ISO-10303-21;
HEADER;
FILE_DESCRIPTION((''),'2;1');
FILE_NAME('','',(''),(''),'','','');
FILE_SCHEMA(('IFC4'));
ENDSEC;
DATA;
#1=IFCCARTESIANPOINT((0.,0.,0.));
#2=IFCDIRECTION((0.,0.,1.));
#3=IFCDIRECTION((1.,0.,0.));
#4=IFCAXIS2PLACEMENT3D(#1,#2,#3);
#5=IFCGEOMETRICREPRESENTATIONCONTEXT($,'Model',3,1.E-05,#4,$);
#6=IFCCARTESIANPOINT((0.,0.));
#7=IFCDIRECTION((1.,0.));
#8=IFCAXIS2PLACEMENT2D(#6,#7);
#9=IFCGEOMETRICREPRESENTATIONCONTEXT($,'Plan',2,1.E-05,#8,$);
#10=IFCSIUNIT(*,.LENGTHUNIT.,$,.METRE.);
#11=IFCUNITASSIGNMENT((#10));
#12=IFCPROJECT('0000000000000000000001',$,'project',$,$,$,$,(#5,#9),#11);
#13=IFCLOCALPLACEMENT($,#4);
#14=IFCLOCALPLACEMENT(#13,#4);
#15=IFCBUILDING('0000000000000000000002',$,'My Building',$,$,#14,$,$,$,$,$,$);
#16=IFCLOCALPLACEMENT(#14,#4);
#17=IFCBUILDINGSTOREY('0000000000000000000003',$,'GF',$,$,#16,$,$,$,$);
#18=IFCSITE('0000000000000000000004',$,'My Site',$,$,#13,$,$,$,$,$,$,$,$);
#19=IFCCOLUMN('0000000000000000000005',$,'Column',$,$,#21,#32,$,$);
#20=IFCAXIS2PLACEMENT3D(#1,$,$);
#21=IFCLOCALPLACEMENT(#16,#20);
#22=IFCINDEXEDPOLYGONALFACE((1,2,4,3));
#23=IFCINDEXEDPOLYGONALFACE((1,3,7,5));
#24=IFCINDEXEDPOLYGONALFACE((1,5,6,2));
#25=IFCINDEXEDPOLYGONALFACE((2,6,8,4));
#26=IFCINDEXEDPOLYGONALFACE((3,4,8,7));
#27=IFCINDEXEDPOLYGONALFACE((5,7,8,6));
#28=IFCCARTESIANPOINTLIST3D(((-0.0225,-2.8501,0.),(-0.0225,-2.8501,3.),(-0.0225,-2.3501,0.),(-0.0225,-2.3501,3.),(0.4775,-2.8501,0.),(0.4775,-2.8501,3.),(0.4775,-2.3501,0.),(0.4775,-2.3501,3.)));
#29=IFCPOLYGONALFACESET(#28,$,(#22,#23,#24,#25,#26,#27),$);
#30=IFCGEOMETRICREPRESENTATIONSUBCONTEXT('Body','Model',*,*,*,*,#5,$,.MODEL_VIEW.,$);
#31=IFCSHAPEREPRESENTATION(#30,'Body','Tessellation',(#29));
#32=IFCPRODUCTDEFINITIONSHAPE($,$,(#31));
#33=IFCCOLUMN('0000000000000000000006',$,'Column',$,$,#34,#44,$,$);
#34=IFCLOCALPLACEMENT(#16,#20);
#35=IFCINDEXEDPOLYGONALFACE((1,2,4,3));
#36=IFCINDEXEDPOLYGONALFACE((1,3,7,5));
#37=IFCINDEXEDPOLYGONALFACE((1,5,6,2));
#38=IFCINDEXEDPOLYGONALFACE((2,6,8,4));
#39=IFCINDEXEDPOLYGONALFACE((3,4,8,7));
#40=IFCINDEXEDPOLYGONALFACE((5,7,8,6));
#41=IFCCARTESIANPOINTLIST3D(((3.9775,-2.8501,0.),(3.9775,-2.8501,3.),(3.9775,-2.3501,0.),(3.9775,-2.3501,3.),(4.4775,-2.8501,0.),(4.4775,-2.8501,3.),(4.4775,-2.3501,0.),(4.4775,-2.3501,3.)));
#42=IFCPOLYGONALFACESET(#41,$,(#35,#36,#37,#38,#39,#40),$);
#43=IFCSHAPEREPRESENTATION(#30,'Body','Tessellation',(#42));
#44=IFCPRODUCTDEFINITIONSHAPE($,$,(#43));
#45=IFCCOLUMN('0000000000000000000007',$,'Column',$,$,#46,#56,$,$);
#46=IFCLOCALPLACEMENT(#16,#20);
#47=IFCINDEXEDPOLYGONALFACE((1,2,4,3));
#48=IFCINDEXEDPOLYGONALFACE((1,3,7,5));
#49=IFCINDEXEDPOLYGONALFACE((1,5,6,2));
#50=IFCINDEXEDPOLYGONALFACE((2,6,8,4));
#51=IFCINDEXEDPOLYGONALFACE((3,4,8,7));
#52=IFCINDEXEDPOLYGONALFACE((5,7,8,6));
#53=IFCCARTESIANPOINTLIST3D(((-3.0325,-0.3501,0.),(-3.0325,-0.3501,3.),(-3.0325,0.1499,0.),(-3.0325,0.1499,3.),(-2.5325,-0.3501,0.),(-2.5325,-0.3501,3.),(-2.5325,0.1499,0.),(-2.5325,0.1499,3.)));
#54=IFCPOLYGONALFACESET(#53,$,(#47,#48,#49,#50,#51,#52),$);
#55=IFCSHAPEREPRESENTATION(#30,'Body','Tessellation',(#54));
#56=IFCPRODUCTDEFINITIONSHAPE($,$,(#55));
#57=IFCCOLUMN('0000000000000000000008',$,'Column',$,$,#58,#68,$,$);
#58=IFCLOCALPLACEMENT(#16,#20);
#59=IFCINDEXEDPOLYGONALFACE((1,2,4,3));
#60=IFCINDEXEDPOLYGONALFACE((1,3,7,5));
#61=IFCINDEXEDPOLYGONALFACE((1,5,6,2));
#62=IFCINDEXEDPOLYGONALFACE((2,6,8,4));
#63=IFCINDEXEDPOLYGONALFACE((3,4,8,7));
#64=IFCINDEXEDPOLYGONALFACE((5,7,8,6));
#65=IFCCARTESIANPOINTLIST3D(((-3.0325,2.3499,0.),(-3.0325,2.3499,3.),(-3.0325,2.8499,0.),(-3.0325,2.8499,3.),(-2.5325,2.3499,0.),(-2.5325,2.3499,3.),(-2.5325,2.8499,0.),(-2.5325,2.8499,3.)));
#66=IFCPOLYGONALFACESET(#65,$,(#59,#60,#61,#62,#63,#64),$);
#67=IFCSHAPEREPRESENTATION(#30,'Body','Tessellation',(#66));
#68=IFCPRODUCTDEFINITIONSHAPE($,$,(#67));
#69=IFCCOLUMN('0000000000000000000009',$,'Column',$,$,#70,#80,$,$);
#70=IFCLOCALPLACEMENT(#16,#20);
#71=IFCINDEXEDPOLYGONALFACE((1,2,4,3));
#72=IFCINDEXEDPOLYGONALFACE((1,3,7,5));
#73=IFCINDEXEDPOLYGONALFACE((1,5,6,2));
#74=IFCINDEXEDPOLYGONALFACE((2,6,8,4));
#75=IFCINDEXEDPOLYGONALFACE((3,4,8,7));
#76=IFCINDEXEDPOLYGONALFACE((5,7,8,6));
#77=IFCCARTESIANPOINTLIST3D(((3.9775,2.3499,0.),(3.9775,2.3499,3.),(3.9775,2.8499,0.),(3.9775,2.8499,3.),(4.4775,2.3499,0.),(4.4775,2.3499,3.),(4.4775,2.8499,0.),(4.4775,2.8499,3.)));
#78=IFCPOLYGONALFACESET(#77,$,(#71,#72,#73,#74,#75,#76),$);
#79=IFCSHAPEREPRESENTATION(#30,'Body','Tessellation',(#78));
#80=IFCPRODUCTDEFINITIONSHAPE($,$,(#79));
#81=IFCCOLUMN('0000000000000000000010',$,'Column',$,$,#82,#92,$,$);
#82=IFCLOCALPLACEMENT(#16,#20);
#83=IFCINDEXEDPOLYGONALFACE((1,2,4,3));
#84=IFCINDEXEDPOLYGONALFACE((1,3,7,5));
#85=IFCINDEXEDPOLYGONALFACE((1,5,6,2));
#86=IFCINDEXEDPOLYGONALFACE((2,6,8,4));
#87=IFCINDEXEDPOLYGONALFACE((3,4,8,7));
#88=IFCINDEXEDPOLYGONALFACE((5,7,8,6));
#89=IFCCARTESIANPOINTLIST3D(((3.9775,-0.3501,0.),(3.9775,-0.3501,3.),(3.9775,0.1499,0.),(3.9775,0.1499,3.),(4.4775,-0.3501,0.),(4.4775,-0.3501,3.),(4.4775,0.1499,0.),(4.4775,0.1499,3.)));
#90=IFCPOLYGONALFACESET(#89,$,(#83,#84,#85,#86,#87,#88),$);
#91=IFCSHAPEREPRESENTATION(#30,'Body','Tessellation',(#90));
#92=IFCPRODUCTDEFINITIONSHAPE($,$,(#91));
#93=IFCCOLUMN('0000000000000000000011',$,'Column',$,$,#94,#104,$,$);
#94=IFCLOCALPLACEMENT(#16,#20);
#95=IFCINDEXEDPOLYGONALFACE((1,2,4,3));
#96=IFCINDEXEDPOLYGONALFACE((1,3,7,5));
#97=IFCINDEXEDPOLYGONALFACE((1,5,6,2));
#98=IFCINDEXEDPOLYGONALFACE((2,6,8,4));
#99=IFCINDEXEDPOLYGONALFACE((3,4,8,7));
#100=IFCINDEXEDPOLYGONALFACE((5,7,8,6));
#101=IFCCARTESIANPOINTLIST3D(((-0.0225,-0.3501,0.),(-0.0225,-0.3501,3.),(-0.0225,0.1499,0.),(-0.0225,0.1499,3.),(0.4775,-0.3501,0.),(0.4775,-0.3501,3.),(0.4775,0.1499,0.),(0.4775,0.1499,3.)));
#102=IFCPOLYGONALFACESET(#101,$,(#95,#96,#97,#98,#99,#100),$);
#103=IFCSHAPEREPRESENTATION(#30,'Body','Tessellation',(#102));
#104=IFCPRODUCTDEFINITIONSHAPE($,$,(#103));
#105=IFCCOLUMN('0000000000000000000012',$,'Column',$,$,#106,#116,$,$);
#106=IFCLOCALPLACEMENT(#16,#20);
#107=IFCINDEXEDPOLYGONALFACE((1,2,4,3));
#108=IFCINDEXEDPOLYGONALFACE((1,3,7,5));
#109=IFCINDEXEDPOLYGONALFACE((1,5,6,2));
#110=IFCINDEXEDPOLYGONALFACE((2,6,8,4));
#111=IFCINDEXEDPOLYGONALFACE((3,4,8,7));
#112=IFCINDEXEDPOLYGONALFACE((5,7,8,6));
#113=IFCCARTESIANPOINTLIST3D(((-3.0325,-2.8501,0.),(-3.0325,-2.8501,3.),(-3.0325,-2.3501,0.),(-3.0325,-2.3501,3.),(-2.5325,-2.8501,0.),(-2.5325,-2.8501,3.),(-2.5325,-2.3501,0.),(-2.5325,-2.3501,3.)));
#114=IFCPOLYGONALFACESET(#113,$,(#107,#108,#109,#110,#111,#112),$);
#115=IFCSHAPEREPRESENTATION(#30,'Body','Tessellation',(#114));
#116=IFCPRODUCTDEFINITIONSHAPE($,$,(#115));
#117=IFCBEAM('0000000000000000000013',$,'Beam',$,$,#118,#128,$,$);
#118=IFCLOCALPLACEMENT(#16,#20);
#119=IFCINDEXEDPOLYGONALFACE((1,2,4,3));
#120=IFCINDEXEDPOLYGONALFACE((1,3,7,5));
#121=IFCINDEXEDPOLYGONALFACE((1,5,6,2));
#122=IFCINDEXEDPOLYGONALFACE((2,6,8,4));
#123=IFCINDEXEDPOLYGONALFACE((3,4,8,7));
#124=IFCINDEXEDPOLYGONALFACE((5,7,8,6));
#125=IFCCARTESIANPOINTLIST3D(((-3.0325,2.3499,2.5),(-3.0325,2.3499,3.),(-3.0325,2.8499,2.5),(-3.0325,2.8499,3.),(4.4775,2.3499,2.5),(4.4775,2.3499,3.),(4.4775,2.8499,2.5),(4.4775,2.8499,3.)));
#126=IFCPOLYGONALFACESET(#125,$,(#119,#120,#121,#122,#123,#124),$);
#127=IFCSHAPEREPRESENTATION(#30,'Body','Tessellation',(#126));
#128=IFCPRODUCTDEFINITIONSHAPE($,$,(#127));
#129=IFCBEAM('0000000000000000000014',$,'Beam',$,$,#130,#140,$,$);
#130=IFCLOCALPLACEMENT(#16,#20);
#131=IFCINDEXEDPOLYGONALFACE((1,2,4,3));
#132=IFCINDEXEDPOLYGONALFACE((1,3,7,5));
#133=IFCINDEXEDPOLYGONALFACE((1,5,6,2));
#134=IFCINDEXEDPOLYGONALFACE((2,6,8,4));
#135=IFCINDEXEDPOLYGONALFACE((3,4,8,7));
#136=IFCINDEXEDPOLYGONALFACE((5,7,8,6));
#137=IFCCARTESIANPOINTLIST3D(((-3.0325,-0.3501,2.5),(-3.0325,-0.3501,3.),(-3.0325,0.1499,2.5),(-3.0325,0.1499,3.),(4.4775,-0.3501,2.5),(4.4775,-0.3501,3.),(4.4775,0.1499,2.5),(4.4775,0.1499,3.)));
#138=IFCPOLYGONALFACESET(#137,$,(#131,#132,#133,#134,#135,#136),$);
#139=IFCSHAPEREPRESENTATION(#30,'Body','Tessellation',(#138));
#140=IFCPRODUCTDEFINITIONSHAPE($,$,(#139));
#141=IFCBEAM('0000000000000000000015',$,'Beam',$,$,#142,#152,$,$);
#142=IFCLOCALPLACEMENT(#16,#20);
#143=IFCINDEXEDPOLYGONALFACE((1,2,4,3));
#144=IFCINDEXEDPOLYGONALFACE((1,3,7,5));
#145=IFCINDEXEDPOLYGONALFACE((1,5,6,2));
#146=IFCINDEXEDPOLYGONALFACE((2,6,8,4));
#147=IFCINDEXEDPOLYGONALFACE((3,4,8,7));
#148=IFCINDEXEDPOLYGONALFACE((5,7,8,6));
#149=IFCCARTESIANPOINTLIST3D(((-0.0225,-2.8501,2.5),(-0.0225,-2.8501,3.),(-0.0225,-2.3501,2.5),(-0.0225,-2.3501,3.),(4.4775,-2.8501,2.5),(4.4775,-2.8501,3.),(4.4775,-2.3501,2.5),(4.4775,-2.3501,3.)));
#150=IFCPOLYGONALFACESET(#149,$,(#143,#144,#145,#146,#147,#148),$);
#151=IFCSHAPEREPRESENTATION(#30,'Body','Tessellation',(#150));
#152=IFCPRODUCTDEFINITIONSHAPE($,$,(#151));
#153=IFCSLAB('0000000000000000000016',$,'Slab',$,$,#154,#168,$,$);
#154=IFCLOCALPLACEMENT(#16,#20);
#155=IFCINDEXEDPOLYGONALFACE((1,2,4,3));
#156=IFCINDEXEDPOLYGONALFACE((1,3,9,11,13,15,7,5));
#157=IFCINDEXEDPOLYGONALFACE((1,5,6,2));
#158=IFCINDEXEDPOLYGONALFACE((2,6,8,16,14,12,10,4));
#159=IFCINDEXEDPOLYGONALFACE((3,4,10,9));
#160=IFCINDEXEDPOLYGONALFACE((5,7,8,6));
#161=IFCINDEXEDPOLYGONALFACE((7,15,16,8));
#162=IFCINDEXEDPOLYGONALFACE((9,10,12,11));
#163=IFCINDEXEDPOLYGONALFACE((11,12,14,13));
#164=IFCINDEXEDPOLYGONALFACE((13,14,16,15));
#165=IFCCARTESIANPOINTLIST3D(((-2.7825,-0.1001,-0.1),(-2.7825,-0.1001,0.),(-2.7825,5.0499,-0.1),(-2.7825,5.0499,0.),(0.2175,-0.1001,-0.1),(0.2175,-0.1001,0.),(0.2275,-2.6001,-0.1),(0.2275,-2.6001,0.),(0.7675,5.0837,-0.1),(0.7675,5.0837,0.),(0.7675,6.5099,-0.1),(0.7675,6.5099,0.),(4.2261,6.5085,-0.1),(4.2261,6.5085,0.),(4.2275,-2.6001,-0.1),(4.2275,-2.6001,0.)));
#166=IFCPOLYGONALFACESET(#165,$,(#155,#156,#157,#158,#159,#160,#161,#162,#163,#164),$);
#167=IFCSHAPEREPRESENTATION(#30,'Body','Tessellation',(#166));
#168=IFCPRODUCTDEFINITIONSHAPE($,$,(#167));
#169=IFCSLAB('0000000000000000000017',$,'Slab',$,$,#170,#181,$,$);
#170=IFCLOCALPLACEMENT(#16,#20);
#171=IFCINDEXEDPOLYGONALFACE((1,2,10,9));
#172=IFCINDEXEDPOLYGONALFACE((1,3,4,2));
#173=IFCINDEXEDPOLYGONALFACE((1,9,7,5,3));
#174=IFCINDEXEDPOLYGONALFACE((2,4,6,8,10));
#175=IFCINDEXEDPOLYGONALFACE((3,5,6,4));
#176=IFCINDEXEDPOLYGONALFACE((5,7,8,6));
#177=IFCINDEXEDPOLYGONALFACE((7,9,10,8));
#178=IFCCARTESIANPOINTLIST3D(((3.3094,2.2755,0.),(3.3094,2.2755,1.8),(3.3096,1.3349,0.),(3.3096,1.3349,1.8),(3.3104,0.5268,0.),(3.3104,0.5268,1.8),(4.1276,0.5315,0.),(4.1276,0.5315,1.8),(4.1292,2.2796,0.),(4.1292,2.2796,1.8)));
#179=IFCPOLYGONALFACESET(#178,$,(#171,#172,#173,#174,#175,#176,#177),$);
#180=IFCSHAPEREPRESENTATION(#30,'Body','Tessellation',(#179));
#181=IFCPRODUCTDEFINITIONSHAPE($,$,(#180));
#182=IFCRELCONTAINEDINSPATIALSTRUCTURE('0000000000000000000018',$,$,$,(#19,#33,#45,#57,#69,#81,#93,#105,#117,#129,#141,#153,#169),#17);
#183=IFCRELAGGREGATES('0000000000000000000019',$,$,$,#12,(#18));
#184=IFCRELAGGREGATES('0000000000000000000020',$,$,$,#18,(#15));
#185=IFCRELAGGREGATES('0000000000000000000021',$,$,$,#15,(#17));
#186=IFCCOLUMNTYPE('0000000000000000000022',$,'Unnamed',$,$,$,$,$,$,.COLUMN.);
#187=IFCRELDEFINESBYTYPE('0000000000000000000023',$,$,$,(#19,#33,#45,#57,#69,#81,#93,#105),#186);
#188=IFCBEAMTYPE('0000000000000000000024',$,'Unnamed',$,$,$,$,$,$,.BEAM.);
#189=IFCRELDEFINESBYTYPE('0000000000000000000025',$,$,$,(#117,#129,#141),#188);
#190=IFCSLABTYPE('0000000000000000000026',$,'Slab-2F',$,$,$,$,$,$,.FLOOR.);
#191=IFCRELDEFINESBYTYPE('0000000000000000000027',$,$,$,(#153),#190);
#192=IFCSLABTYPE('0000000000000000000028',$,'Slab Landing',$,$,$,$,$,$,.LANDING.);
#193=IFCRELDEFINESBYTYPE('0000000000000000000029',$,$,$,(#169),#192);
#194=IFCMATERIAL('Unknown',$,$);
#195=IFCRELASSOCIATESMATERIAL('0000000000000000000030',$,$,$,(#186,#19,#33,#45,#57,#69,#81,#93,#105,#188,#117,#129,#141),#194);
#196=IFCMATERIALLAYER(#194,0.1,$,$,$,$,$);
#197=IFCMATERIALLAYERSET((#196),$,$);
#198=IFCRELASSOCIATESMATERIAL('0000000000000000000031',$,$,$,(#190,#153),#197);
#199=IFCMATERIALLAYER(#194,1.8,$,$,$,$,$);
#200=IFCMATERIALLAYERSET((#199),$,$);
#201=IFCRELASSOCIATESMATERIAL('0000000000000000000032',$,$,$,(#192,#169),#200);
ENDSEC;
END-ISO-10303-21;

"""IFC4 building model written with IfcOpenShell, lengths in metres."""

from ifc_helpers import new_model, si_unit, frame, origin_with_axes, origin_2d_with_axis, place, context, subcontext, project, spatial, indexed_curve, rectangle, outline, extrude, material, layer, layer_set, layer_usage, material_profile, profile_set, profile_usage, type_object, element, save


model = new_model("IFC4")

# Units and contexts
model_context = context("Model", 3, precision=1e-05, world=origin_with_axes())
plan_context = context("Plan", 2, precision=1e-05, world=origin_2d_with_axis())
body_context_1 = subcontext(model_context, "Body", "Model", "MODEL_VIEW")
ifc_project = project(units=[si_unit("LENGTHUNIT", "METRE")], contexts=[model_context, plan_context])

# Site, building, storey
site_placement = place(None, origin_with_axes())
site = spatial("IfcSite", under=ifc_project, at=site_placement, Name="My Site")
building_placement = place(site_placement, origin_with_axes())
building = spatial("IfcBuilding", under=site, at=building_placement, Name="My Building")
storey_placement = place(building_placement, origin_with_axes())
storey = spatial("IfcBuildingStorey", under=building, at=storey_placement, Name="GF")

# Columns
ifc_material = material(Name="Unknown")
ifc_material_profile_1 = material_profile(ifc_material, rectangle(XDim=0.5, YDim=0.5))
ifc_profile_set_1 = profile_set([ifc_material_profile_1])
ifc_profile_usage_1 = profile_usage(ifc_profile_set_1, cardinal=5)
column_type = type_object("IfcColumnType", Name="Unnamed", PredefinedType="COLUMN", material=ifc_profile_set_1)
column_1_placement = place(storey_placement, frame((0.2275, -2.6001, 0.0), z_axis=(0.0, 0.0, 1.0), x_axis=(1.0, 0.0, 0.0)))
element("IfcColumn", 1, at=column_1_placement, inside=storey, type_object=column_type, material=ifc_profile_usage_1, Name="Column", context=body_context_1, shape_type="SweptSolid", body=[
    extrude(rectangle(XDim=0.5, YDim=0.5), origin_with_axes(), (0.0, 0.0, 1.0), 3.0),
])
ifc_profile_usage_2 = profile_usage(ifc_profile_set_1, cardinal=5)
column_2_placement = place(storey_placement, frame((4.2275, -2.6001, 0.0), z_axis=(0.0, 0.0, 1.0), x_axis=(1.0, 0.0, 0.0)))
element("IfcColumn", 2, at=column_2_placement, inside=storey, type_object=column_type, material=ifc_profile_usage_2, Name="Column", context=body_context_1, shape_type="SweptSolid", body=[
    extrude(rectangle(XDim=0.5, YDim=0.5), origin_with_axes(), (0.0, 0.0, 1.0), 3.0),
])
ifc_profile_usage_3 = profile_usage(ifc_profile_set_1, cardinal=5)
column_3_placement = place(storey_placement, frame((-2.7825, -0.1001, 0.0), z_axis=(0.0, 0.0, 1.0), x_axis=(1.0, 0.0, 0.0)))
element("IfcColumn", 3, at=column_3_placement, inside=storey, type_object=column_type, material=ifc_profile_usage_3, Name="Column", context=body_context_1, shape_type="SweptSolid", body=[
    extrude(rectangle(XDim=0.5, YDim=0.5), origin_with_axes(), (0.0, 0.0, 1.0), 3.0),
])
ifc_profile_usage_4 = profile_usage(ifc_profile_set_1, cardinal=5)
column_4_placement = place(storey_placement, frame((-2.7825, 2.5999, 0.0), z_axis=(0.0, 0.0, 1.0), x_axis=(1.0, 0.0, 0.0)))
element("IfcColumn", 4, at=column_4_placement, inside=storey, type_object=column_type, material=ifc_profile_usage_4, Name="Column", context=body_context_1, shape_type="SweptSolid", body=[
    extrude(rectangle(XDim=0.5, YDim=0.5), origin_with_axes(), (0.0, 0.0, 1.0), 3.0),
])
ifc_profile_usage_5 = profile_usage(ifc_profile_set_1, cardinal=5)
column_5_placement = place(storey_placement, frame((4.2275, 2.5999, 0.0), z_axis=(0.0, 0.0, 1.0), x_axis=(1.0, 0.0, 0.0)))
element("IfcColumn", 5, at=column_5_placement, inside=storey, type_object=column_type, material=ifc_profile_usage_5, Name="Column", context=body_context_1, shape_type="SweptSolid", body=[
    extrude(rectangle(XDim=0.5, YDim=0.5), origin_with_axes(), (0.0, 0.0, 1.0), 3.0),
])
ifc_profile_usage_6 = profile_usage(ifc_profile_set_1, cardinal=5)
column_6_placement = place(storey_placement, frame((4.2275, -0.1001, 0.0), z_axis=(0.0, 0.0, 1.0), x_axis=(1.0, 0.0, 0.0)))
element("IfcColumn", 6, at=column_6_placement, inside=storey, type_object=column_type, material=ifc_profile_usage_6, Name="Column", context=body_context_1, shape_type="SweptSolid", body=[
    extrude(rectangle(XDim=0.5, YDim=0.5), origin_with_axes(), (0.0, 0.0, 1.0), 3.0),
])
ifc_profile_usage_7 = profile_usage(ifc_profile_set_1, cardinal=5)
column_7_placement = place(storey_placement, frame((0.2275, -0.1001, 0.0), z_axis=(0.0, 0.0, 1.0), x_axis=(1.0, 0.0, 0.0)))
element("IfcColumn", 7, at=column_7_placement, inside=storey, type_object=column_type, material=ifc_profile_usage_7, Name="Column", context=body_context_1, shape_type="SweptSolid", body=[
    extrude(rectangle(XDim=0.5, YDim=0.5), origin_with_axes(), (0.0, 0.0, 1.0), 3.0),
])
ifc_profile_usage_8 = profile_usage(ifc_profile_set_1, cardinal=5)
column_8_placement = place(storey_placement, frame((-2.7825, -2.6001, 0.0), z_axis=(0.0, 0.0, 1.0), x_axis=(1.0, 0.0, 0.0)))
element("IfcColumn", 8, at=column_8_placement, inside=storey, type_object=column_type, material=ifc_profile_usage_8, Name="Column", context=body_context_1, shape_type="SweptSolid", body=[
    extrude(rectangle(XDim=0.5, YDim=0.5), origin_with_axes(), (0.0, 0.0, 1.0), 3.0),
])

# Beams
ifc_material_profile_2 = material_profile(ifc_material, rectangle(XDim=0.5, YDim=0.5))
ifc_profile_set_2 = profile_set([ifc_material_profile_2])
ifc_profile_usage_9 = profile_usage(ifc_profile_set_2, cardinal=7)
beam_type = type_object("IfcBeamType", Name="Unnamed", PredefinedType="BEAM", material=ifc_profile_set_2)
beam_1_placement = place(storey_placement, frame((4.4775, 2.3499, 3.0), z_axis=(-1.0, 0.0, 0.0), x_axis=(0.0, -1.0, 0.0)))
element("IfcBeam", 9, at=beam_1_placement, inside=storey, type_object=beam_type, material=ifc_profile_usage_9, Name="Beam", context=body_context_1, shape_type="SweptSolid", body=[
    extrude(rectangle(XDim=0.5, YDim=0.5), frame((-0.25, -0.25, 0.0), z_axis=(0.0, 0.0, 1.0), x_axis=(1.0, 0.0, 0.0)), (0.0, 0.0, 1.0), 7.51),
])
ifc_profile_usage_10 = profile_usage(ifc_profile_set_2, cardinal=7)
beam_2_placement = place(storey_placement, frame((-3.0325, 0.1499, 3.0), z_axis=(1.0, 0.0, 0.0), x_axis=(0.0, 1.0, 0.0)))
element("IfcBeam", 10, at=beam_2_placement, inside=storey, type_object=beam_type, material=ifc_profile_usage_10, Name="Beam", context=body_context_1, shape_type="SweptSolid", body=[
    extrude(rectangle(XDim=0.5, YDim=0.5), frame((-0.25, -0.25, 0.0), z_axis=(0.0, 0.0, 1.0), x_axis=(1.0, 0.0, 0.0)), (0.0, 0.0, 1.0), 7.51),
])
ifc_profile_usage_11 = profile_usage(ifc_profile_set_2, cardinal=7)
beam_3_placement = place(storey_placement, frame((4.4775, -2.8501, 3.0), z_axis=(-1.0, -0.000001, 0.000001), x_axis=(0.000001, -1.0, 0.000001)))
element("IfcBeam", 11, at=beam_3_placement, inside=storey, type_object=beam_type, material=ifc_profile_usage_11, Name="Beam", context=body_context_1, shape_type="SweptSolid", body=[
    extrude(rectangle(XDim=0.5, YDim=0.5), frame((-0.25, -0.25, 0.0), z_axis=(0.0, 0.0, 1.0), x_axis=(1.0, 0.0, 0.0)), (0.0, 0.0, 1.0), 4.5),
])

# Slabs
ifc_layer_1 = layer(ifc_material, 0.1)
ifc_layer_set_1 = layer_set([ifc_layer_1])
ifc_layer_usage_1 = layer_usage(ifc_layer_set_1, "AXIS3", "POSITIVE", -0.1)
slab_type_1 = type_object("IfcSlabType", Name="Slab-2F", PredefinedType="FLOOR", material=ifc_layer_set_1)
slab_1_placement = place(storey_placement, frame((4.2275, -2.6001, 0.0), z_axis=(0.0, 0.0, 1.0), x_axis=(1.0, 0.0, 0.0)))
element("IfcSlab", 12, at=slab_1_placement, inside=storey, type_object=slab_type_1, material=ifc_layer_usage_1, Name="Slab", context=body_context_1, shape_type="SweptSolid", body=[
    extrude(outline(indexed_curve([(0.0, 0.0), (-0.0014, 9.1086), (-3.46, 9.11), (-3.46, 7.6838), (-7.01, 7.65), (-7.01, 2.5), (-4.01, 2.5), (-4.0, 0.0), (0.0, 0.0)])), frame((0.0, 0.0, -0.1), z_axis=(0.0, 0.0, 1.0), x_axis=(1.0, 0.0, 0.0)), (0.0, 0.0, 1.0), 0.1),
])
ifc_layer_2 = layer(ifc_material, 1.8)
ifc_layer_set_2 = layer_set([ifc_layer_2])
ifc_layer_usage_2 = layer_usage(ifc_layer_set_2, "AXIS3", "POSITIVE", -0.1)
slab_type_2 = type_object("IfcSlabType", Name="Slab Landing", PredefinedType="LANDING", material=ifc_layer_set_2)
slab_2_placement = place(storey_placement, frame((3.3096, 1.3349, 0.1), z_axis=(0.0, 0.0, 1.0), x_axis=(1.0, 0.0, 0.0)))
element("IfcSlab", 13, at=slab_2_placement, inside=storey, type_object=slab_type_2, material=ifc_layer_usage_2, Name="Slab", context=body_context_1, shape_type="SweptSolid", body=[
    extrude(outline(indexed_curve([(0.0, 0.0), (0.0008, -0.8081), (0.818, -0.8034), (0.8196, 0.9447), (-0.0002, 0.9407), (0.0, 0.0)])), frame((0.0, 0.0, -0.1), z_axis=(0.0, 0.0, 1.0), x_axis=(1.0, 0.0, 0.0)), (0.0, 0.0, 1.0), 1.8),
])

save(model, "model.ifc")
